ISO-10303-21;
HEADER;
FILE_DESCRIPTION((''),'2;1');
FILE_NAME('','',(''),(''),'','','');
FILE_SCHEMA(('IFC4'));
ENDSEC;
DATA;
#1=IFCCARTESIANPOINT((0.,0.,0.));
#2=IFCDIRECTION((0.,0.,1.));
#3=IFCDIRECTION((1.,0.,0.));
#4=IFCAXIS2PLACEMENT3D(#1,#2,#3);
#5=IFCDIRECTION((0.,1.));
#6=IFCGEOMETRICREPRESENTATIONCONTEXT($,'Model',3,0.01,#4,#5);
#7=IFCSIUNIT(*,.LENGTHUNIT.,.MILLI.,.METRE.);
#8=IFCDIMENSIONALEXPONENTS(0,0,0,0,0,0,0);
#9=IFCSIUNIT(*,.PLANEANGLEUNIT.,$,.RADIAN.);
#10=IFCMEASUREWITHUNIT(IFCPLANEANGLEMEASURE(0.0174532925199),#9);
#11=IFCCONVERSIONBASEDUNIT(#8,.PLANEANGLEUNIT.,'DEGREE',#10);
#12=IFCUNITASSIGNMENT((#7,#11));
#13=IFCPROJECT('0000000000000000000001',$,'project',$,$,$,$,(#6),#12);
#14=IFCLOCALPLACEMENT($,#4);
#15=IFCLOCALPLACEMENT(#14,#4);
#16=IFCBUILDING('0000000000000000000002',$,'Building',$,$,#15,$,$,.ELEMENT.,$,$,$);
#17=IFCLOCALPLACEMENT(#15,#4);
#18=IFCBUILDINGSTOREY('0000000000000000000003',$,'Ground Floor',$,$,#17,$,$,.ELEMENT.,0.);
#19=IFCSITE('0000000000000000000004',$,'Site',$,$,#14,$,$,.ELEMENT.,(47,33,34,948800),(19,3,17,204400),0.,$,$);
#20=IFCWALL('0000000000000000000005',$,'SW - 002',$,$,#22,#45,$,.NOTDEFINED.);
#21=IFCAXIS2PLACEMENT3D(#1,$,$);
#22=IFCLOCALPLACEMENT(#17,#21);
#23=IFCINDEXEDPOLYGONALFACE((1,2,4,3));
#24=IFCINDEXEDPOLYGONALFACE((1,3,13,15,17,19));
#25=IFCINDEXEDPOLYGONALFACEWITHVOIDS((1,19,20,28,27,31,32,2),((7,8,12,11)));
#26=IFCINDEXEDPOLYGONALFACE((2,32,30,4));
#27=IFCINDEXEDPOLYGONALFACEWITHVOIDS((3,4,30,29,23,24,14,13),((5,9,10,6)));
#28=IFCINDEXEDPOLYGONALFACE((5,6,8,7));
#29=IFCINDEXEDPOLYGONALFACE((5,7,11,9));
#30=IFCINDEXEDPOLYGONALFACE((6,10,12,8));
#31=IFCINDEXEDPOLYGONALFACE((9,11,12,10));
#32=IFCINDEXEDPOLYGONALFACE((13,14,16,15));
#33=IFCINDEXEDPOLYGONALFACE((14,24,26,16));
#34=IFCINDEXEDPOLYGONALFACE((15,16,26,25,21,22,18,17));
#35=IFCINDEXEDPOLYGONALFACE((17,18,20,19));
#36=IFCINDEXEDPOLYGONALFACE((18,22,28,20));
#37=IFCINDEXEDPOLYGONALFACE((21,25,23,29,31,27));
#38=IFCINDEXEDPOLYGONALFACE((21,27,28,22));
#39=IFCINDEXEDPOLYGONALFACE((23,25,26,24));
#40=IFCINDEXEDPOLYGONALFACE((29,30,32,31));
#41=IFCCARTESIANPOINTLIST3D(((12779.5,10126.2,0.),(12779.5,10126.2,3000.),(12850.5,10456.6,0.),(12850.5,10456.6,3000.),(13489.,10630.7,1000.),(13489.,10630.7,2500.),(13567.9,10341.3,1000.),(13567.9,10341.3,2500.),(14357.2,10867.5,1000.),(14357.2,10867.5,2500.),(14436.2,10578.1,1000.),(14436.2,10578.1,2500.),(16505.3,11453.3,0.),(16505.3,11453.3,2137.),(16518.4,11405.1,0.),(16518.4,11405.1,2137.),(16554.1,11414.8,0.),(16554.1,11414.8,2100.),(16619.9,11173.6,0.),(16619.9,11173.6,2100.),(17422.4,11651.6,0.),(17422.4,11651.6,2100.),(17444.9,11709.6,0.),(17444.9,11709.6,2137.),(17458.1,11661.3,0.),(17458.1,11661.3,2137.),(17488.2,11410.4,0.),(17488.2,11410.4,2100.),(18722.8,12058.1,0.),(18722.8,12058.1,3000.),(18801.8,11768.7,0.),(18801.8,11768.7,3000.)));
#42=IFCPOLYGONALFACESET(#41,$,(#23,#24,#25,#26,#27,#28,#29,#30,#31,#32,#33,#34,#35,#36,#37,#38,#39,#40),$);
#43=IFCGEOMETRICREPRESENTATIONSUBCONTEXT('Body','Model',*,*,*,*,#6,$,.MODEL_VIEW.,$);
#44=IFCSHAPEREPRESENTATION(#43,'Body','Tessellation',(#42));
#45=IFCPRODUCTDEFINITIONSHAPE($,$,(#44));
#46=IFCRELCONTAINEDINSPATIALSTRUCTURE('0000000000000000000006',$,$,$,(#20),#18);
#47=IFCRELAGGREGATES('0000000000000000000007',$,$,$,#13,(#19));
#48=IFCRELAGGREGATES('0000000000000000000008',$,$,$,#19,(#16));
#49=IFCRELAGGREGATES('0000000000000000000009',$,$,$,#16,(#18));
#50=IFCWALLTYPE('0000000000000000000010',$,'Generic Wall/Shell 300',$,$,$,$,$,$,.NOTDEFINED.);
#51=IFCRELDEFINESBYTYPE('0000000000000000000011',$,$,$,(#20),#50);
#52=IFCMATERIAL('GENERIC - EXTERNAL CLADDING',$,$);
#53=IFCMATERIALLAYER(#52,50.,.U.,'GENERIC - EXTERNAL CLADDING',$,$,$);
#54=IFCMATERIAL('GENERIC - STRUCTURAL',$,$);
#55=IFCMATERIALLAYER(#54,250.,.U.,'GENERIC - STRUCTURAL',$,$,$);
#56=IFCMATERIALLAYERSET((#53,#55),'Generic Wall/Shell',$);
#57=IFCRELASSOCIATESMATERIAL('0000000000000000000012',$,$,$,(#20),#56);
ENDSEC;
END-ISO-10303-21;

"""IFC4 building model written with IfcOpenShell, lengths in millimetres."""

from ifc_helpers import new_model, entity, si_unit, converted_unit, direction, frame, origin_with_axes, origin_2d_with_axis, place, context, subcontext, project, spatial, line, indexed_curve, rectangle, outline, extrude, source, transform, mapped, material, layer, layer_set, layer_usage, type_object, element, save


model = new_model("IFC4")

# Units and contexts
model_context = context("Model", 3, precision=0.01, world=origin_with_axes(), true_north=direction((0.0, 1.0)))
body_context = subcontext(model_context, "Body", "Model", "MODEL_VIEW")
ifc_project = project(units=[si_unit("LENGTHUNIT", "METRE", prefix="MILLI"), converted_unit("PLANEANGLEUNIT", "DEGREE", entity("IfcPlaneAngleMeasure", 0.0174532925199), si_unit("PLANEANGLEUNIT", "RADIAN"), dimensions=[0, 0, 0, 0, 0, 0, 0])], contexts=[model_context])

# Site, building, storey
site_placement = place(None, origin_with_axes())
site = spatial("IfcSite", under=ifc_project, at=site_placement, Name="Site", CompositionType="ELEMENT", RefLatitude=(47, 33, 34, 948800), RefLongitude=(19, 3, 17, 204400), RefElevation=0.0)
building_placement = place(site_placement, origin_with_axes())
building = spatial("IfcBuilding", under=site, at=building_placement, Name="Building", CompositionType="ELEMENT")
storey_placement = place(building_placement, origin_with_axes())
storey = spatial("IfcBuildingStorey", under=building, at=storey_placement, Name="Ground Floor", CompositionType="ELEMENT", Elevation=0.0)

# Wall, openings
ifc_material_1 = material(Name="GENERIC - EXTERNAL CLADDING")
ifc_layer_1 = layer(ifc_material_1, 50.0, ventilated="UNKNOWN", Name="GENERIC - EXTERNAL CLADDING")
ifc_material_2 = material(Name="GENERIC - STRUCTURAL")
ifc_layer_2 = layer(ifc_material_2, 250.0, ventilated="UNKNOWN", Name="GENERIC - STRUCTURAL")
ifc_layer_set = layer_set([ifc_layer_1, ifc_layer_2], Name="Generic Wall/Shell")
wall_type = type_object("IfcWallType", Name="Generic Wall/Shell 300", PredefinedType="NOTDEFINED")
ifc_layer_usage_1 = layer_usage(ifc_layer_set, "AXIS2", "POSITIVE", -50.0)
wall_1_placement = place(storey_placement, frame((12791.4, 10181.3, 0.0), z_axis=(0.0, 0.0, 1.0), x_axis=(0.964764, 0.263117, 0.0)))
wall_1 = element("IfcWall", 1, at=wall_1_placement, inside=storey, type_object=wall_type, material=ifc_layer_usage_1, Name="SW - 002", PredefinedType="NOTDEFINED", context=body_context, shape_type="SweptSolid", body=[
    extrude(outline(indexed_curve([(-25.9, -50.0), (6216.3, -50.0), (6216.3, 250.0), (129.5, 250.0)], segments=[line(1, 2, 3, 4, 1)])), origin_with_axes(), (0.0, 0.0, 1.0), 3000.0),
])
shared_shape_1 = source(origin_with_axes(), body_context, "Body", "SweptSolid", [
    extrude(rectangle(XDim=900.0, YDim=1500.0, at=origin_2d_with_axis()), frame((0.0, 0.0, 750.0), z_axis=(0.0, -1.0, 0.0), x_axis=(1.0, 0.0, 0.0)), (0.0, 0.0, -1.0), 550.0),
    extrude(rectangle(XDim=900.0, YDim=1500.0, at=origin_2d_with_axis()), frame((0.0, 0.0, 750.0), z_axis=(0.0, 1.0, 0.0), x_axis=(1.0, 0.0, 0.0)), (0.0, 0.0, -1.0), 350.0),
])
opening_1_placement = place(wall_1_placement, frame((1241.2, -50.0, 1000.0), z_axis=(0.0, 0.0, 1.0), x_axis=(1.0, 0.0, 0.0)))
element("IfcOpeningElement", 2, at=opening_1_placement, cuts=wall_1, PredefinedType="OPENING", context=body_context, shape_type="MappedRepresentation", body=[
    mapped(shared_shape_1, transform((0.0, 0.0, 0.0), x_axis=(1.0, 0.0, 0.0), y_axis=(0.0, 1.0, 0.0), z_axis=(0.0, 0.0, 1.0), scale=1.0)),
])
shared_shape_2 = source(origin_with_axes(), body_context, "Body", "SweptSolid", [
    extrude(rectangle(XDim=900.0, YDim=2100.0, at=origin_2d_with_axis()), frame((0.0, 300.0, 1050.0), z_axis=(0.0, 1.0, 0.0), x_axis=(-1.0, 0.0, 0.0)), (0.0, 0.0, -1.0), 900.0),
    extrude(rectangle(XDim=974.0, YDim=2137.0, at=origin_2d_with_axis()), frame((0.0, 250.0, 1068.5), z_axis=(0.0, 1.0, 0.0), x_axis=(-1.0, 0.0, 0.0)), (0.0, 0.0, 1.0), 300.0),
    extrude(rectangle(XDim=974.0, YDim=2137.0, at=origin_2d_with_axis()), frame((0.0, -50.0, 1068.5), z_axis=(0.0, -1.0, 0.0), x_axis=(-1.0, 0.0, 0.0)), (0.0, 0.0, 1.0), 300.0),
])
opening_2_placement = place(wall_1_placement, frame((4404.7, -50.0, 0.0), z_axis=(0.0, 0.0, 1.0), x_axis=(1.0, 0.0, 0.0)))
element("IfcOpeningElement", 3, at=opening_2_placement, cuts=wall_1, PredefinedType="OPENING", context=body_context, shape_type="MappedRepresentation", body=[
    mapped(shared_shape_2, transform((0.0, 0.0, 0.0), x_axis=(1.0, 0.0, 0.0), y_axis=(0.0, 1.0, 0.0), z_axis=(0.0, 0.0, 1.0), scale=1.0)),
])

save(model, "model.ifc")
